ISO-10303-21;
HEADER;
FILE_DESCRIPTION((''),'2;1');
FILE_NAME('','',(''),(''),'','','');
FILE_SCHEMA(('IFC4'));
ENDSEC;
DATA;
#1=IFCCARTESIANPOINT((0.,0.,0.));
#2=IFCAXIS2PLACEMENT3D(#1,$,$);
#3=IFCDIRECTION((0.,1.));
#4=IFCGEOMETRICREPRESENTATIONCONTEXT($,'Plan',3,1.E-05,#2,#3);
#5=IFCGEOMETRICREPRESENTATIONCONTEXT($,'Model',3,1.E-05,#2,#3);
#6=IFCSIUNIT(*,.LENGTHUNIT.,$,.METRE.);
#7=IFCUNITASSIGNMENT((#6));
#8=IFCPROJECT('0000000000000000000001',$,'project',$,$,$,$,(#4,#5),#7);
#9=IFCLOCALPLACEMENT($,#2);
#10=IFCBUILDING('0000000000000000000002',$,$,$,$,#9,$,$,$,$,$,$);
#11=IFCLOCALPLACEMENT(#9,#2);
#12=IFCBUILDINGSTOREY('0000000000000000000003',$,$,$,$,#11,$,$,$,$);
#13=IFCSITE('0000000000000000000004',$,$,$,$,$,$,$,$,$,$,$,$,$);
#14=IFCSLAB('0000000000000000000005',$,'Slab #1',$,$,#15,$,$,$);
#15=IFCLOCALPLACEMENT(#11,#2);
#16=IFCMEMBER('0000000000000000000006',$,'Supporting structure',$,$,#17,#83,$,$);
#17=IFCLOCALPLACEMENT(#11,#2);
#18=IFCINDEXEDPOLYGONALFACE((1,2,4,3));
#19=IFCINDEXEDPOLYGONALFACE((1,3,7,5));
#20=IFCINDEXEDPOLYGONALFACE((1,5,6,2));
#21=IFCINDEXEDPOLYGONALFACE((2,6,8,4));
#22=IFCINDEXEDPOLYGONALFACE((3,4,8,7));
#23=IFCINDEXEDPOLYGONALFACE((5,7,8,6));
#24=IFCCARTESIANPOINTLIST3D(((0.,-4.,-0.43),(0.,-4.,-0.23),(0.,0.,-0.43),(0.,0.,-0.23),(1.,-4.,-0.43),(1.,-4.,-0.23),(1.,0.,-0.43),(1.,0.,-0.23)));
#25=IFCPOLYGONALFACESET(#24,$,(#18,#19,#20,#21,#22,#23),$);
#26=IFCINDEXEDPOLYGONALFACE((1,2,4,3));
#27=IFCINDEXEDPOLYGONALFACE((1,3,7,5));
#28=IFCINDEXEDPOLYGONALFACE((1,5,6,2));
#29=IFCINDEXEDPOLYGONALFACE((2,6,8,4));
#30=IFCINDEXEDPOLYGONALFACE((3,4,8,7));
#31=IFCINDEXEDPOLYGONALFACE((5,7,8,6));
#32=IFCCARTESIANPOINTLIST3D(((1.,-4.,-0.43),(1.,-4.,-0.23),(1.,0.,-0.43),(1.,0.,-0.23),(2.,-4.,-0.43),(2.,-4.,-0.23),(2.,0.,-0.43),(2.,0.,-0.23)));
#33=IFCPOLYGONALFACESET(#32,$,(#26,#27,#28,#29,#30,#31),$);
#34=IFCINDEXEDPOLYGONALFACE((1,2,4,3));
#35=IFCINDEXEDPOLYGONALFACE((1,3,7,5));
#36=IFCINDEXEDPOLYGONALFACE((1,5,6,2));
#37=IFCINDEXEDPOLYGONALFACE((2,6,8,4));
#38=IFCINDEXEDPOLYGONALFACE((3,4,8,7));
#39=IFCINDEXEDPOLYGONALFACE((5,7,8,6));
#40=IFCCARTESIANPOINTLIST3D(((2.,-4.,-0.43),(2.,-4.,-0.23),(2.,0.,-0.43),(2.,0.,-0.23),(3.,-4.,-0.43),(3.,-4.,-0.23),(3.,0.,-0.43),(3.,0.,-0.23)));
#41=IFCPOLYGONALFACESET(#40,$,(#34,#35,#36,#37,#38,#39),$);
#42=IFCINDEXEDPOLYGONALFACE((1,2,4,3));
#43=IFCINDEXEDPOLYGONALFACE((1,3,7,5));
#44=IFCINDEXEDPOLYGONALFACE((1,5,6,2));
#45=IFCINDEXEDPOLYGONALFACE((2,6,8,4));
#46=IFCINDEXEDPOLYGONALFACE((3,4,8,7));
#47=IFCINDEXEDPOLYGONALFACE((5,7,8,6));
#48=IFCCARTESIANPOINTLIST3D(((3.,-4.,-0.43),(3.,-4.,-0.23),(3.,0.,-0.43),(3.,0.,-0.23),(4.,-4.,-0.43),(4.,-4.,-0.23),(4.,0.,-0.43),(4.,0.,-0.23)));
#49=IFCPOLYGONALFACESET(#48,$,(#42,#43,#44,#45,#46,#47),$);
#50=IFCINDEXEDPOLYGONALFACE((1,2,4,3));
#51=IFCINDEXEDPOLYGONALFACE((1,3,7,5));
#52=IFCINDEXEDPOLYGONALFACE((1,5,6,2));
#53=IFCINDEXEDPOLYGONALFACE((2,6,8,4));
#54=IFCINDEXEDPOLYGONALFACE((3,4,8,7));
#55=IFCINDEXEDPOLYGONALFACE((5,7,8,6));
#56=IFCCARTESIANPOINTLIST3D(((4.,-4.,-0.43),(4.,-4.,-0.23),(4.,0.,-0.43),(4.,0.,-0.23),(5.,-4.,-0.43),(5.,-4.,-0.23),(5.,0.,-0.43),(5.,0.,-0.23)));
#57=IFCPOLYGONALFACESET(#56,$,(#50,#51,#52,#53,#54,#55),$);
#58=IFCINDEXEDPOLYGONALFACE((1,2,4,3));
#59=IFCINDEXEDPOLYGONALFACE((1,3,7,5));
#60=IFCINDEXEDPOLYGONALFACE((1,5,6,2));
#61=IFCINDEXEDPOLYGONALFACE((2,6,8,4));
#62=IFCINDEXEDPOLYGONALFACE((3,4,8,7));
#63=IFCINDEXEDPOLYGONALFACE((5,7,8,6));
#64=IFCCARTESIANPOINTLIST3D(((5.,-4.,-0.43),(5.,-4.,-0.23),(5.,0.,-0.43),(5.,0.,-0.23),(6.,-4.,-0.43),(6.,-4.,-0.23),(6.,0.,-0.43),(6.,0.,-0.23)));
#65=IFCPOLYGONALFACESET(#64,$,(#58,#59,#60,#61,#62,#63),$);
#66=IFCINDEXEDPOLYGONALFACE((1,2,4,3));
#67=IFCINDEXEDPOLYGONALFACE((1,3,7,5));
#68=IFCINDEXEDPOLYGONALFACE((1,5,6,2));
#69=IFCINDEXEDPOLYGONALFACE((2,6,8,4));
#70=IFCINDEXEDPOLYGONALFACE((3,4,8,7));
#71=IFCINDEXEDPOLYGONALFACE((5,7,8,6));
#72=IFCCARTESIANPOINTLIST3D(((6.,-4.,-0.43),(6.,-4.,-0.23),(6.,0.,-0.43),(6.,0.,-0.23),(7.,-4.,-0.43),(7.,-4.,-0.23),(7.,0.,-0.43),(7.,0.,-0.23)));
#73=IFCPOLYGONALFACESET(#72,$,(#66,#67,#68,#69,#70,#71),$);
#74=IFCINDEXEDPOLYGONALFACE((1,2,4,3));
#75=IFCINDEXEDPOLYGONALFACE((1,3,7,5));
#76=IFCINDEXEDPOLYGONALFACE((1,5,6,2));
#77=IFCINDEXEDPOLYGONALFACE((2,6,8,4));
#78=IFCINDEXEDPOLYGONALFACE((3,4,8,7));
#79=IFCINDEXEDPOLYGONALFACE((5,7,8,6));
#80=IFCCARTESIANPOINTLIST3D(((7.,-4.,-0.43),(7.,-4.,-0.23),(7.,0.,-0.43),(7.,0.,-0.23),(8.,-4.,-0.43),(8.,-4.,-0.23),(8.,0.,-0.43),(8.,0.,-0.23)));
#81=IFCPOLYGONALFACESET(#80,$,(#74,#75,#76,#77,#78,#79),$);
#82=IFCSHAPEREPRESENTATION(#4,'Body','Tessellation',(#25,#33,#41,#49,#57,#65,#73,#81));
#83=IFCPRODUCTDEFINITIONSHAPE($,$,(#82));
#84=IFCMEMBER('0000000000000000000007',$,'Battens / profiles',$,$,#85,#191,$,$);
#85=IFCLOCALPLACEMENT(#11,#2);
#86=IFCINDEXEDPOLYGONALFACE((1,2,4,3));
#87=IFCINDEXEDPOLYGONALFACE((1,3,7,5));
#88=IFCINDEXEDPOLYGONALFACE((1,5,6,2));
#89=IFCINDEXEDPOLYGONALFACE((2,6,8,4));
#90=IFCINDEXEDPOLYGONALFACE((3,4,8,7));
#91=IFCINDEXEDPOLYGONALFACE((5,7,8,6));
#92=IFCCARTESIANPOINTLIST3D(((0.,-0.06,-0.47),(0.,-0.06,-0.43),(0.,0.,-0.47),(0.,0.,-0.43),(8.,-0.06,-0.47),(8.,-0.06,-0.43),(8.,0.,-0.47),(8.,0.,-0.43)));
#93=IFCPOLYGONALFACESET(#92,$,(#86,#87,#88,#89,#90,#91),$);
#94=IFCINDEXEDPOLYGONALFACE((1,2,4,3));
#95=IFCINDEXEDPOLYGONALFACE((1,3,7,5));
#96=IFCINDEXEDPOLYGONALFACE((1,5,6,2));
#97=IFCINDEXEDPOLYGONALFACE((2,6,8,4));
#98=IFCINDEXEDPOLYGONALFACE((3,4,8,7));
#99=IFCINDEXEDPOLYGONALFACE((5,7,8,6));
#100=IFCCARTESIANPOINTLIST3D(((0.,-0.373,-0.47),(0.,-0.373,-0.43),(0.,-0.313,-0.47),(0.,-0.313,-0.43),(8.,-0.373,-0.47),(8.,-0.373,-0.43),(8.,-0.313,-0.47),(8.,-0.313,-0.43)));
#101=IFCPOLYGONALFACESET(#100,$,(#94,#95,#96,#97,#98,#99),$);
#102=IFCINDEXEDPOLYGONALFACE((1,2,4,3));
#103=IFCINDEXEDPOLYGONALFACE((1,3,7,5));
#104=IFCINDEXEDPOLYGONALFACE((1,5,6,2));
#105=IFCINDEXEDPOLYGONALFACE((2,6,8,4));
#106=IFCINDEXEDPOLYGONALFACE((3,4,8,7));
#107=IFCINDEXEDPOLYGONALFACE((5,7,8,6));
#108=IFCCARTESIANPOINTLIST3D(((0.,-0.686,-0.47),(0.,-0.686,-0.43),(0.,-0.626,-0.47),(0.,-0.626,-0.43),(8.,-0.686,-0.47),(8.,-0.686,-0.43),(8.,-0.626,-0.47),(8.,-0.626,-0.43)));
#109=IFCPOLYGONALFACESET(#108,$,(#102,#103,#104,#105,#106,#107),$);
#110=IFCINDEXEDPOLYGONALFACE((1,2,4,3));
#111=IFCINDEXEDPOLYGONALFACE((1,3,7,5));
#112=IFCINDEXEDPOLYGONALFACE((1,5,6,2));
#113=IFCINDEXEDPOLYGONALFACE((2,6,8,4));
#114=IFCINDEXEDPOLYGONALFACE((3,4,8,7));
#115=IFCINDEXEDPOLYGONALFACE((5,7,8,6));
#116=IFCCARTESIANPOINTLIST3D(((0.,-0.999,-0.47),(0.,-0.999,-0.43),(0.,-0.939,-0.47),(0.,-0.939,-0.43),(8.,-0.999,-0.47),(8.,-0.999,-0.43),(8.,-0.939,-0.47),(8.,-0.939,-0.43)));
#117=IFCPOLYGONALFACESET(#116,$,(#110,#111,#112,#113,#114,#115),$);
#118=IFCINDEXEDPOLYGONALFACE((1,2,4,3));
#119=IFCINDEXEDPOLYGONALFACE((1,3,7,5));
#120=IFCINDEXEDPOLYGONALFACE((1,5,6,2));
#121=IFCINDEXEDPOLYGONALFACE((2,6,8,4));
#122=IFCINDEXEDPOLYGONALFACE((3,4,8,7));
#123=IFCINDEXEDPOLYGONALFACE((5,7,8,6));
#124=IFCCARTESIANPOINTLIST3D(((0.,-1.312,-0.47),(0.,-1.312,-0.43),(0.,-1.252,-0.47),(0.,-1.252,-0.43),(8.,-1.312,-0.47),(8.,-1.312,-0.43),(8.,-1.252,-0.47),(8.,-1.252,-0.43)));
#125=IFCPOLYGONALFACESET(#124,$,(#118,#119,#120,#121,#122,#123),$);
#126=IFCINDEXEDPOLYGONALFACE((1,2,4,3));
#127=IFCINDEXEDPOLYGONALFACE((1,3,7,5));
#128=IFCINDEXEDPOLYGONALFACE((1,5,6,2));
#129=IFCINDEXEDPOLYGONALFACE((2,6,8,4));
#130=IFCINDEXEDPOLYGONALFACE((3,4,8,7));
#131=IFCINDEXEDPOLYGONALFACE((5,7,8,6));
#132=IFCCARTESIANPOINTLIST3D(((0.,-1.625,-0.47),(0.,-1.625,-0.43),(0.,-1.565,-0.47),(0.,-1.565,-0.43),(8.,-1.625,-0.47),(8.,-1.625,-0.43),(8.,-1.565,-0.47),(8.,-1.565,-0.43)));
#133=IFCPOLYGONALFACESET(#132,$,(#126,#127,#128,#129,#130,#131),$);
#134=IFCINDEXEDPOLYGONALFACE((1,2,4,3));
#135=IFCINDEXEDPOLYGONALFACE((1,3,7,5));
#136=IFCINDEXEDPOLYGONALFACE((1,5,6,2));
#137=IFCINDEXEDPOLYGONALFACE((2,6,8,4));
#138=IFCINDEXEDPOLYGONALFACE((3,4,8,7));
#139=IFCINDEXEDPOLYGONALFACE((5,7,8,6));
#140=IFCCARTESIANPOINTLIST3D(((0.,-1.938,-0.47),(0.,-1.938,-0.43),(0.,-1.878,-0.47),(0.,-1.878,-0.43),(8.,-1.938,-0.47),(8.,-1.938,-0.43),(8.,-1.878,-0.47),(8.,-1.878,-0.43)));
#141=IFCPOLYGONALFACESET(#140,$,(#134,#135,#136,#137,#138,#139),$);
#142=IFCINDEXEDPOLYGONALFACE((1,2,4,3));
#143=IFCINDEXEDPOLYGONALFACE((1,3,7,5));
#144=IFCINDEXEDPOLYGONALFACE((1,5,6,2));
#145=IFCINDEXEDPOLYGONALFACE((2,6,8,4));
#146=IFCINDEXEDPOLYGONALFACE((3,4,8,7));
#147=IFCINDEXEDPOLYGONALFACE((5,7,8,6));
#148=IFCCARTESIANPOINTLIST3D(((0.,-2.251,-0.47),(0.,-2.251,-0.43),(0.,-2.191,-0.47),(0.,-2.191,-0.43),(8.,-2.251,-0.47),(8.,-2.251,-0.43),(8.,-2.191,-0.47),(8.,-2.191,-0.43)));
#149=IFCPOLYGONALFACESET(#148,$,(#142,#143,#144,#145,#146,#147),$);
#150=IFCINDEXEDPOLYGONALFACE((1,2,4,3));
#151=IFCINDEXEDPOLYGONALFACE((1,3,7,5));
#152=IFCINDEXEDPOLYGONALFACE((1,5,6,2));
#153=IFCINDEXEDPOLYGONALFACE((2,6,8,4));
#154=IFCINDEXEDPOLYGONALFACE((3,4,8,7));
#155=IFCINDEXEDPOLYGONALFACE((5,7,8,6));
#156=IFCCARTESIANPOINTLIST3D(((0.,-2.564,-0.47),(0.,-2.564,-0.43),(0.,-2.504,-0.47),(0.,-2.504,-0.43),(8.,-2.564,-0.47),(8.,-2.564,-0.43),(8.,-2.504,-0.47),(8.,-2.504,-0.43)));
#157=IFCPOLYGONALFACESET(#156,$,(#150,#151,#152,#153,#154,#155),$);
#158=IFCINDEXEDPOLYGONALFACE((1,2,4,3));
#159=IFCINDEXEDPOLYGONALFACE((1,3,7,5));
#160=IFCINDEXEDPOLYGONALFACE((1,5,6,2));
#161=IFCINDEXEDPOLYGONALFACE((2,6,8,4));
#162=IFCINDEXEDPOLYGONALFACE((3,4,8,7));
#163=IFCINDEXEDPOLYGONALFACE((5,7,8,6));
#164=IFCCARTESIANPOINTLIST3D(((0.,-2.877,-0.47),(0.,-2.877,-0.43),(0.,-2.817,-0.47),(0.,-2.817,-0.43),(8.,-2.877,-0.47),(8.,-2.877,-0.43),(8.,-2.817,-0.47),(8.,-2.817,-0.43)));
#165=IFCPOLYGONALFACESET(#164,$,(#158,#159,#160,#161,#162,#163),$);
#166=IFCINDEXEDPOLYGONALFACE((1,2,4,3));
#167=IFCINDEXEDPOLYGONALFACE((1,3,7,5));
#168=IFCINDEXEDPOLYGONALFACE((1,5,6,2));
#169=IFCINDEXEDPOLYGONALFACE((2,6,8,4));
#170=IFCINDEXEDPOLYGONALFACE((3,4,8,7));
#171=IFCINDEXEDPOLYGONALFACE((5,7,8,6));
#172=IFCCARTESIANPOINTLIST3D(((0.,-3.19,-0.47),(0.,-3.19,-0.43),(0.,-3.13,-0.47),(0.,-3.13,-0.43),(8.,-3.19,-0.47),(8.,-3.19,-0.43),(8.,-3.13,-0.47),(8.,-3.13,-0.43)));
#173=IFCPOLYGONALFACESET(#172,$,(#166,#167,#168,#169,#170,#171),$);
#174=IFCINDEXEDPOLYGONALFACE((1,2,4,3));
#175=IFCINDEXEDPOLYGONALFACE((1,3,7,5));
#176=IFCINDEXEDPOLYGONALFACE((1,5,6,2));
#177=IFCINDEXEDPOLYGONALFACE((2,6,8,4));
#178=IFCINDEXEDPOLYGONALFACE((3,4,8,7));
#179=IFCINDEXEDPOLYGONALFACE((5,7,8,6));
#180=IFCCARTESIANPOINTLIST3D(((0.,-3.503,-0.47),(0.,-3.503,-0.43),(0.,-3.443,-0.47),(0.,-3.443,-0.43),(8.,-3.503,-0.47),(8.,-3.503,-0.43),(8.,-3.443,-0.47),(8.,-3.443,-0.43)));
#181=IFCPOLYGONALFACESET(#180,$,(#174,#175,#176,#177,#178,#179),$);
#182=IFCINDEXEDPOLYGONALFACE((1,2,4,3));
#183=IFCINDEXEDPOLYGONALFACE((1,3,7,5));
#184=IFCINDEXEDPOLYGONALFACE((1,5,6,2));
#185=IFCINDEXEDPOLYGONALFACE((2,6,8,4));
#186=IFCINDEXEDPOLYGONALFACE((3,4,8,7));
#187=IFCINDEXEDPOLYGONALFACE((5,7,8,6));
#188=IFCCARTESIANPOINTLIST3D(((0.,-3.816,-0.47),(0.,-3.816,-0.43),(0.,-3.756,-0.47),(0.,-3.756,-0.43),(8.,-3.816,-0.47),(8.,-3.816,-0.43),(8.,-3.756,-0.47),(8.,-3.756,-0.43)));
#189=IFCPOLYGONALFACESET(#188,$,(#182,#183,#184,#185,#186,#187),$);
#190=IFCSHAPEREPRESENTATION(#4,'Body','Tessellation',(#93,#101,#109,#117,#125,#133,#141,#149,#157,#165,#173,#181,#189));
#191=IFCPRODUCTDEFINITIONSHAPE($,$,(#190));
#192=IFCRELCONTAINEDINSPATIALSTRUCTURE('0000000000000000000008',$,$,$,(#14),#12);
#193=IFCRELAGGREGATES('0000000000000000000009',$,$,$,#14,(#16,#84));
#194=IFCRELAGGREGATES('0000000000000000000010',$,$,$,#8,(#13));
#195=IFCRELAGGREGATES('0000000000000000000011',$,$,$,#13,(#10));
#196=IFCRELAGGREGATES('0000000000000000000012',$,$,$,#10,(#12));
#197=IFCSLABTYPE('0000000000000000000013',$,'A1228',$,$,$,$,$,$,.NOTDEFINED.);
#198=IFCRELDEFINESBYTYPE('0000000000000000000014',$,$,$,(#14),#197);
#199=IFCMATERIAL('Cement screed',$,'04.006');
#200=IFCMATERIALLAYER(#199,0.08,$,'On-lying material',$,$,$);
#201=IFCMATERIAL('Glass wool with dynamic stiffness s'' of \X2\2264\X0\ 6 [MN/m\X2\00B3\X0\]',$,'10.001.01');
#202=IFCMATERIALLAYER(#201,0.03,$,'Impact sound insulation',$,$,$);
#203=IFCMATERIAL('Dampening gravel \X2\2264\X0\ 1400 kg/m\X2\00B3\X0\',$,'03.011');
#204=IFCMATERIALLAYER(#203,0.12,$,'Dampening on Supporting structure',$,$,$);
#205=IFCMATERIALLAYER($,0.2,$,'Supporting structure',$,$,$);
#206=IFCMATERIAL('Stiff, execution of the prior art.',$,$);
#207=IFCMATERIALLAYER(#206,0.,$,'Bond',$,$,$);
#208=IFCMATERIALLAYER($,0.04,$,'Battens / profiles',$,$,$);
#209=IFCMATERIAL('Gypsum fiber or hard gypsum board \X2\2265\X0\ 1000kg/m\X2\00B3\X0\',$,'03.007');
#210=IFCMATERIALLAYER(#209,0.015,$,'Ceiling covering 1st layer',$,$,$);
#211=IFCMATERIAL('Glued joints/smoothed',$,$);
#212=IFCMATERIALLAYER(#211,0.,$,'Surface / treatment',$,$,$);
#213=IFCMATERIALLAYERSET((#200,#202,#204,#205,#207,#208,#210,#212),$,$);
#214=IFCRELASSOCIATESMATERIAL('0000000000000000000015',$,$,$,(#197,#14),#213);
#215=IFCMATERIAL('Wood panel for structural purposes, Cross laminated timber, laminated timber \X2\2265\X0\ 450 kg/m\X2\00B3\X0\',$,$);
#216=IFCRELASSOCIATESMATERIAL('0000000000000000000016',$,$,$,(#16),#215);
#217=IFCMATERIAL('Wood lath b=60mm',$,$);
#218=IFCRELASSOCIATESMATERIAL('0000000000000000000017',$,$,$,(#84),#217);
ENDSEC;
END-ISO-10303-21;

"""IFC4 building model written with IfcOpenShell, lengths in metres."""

from ifc_helpers import new_model, si_unit, direction, frame, frame_2d, origin, place, context, project, spatial, rectangle, extrude, material, layer, layer_set, type_object, element, aggregate, save


model = new_model("IFC4")

# Units and contexts
plan_context = context("Plan", 3, precision=1e-05, world=origin(), true_north=direction((0.0, 1.0)))
model_context = context("Model", 3, precision=1e-05, world=origin(), true_north=direction((0.0, 1.0)))
ifc_project = project(units=[si_unit("LENGTHUNIT", "METRE")], contexts=[plan_context, model_context])

# Site, building, storey
site = spatial("IfcSite", under=ifc_project)
building_placement = place(None, origin())
building = spatial("IfcBuilding", under=site, at=building_placement)
storey_placement = place(building_placement, origin())
storey = spatial("IfcBuildingStorey", under=building, at=storey_placement)

# Slab, members
ifc_material_1 = material(Name="Cement screed", Category="04.006")
ifc_layer_1 = layer(ifc_material_1, 0.08, Name="On-lying material")
ifc_material_2 = material(Name="Glass wool with dynamic stiffness s' of ≤ 6 [MN/m³]", Category="10.001.01")
ifc_layer_2 = layer(ifc_material_2, 0.03, Name="Impact sound insulation")
ifc_material_3 = material(Name="Dampening gravel ≤ 1400 kg/m³", Category="03.011")
ifc_layer_3 = layer(ifc_material_3, 0.12, Name="Dampening on Supporting structure")
ifc_layer_4 = layer(None, 0.2, Name="Supporting structure")
ifc_material_4 = material(Name="Stiff, execution of the prior art.")
ifc_layer_5 = layer(ifc_material_4, 0.0, Name="Bond")
ifc_layer_6 = layer(None, 0.04, Name="Battens / profiles")
ifc_material_5 = material(Name="Gypsum fiber or hard gypsum board ≥ 1000kg/m³", Category="03.007")
ifc_layer_7 = layer(ifc_material_5, 0.015, Name="Ceiling covering 1st layer")
ifc_material_6 = material(Name="Glued joints/smoothed")
ifc_layer_8 = layer(ifc_material_6, 0.0, Name="Surface / treatment")
ifc_layer_set = layer_set([ifc_layer_1, ifc_layer_2, ifc_layer_3, ifc_layer_4, ifc_layer_5, ifc_layer_6, ifc_layer_7, ifc_layer_8])
slab_type = type_object("IfcSlabType", Name="A1228", PredefinedType="NOTDEFINED", material=ifc_layer_set)
slab_placement = place(None, frame((0.0, 0.0, 0.0), z_axis=(0.0, 0.0, -1.0), x_axis=(1.0, 0.0, 0.0)))
slab = element("IfcSlab", 1, at=slab_placement, inside=storey, type_object=slab_type, material=ifc_layer_set, Name="Slab #1")
ifc_material_7 = material(Name="Wood panel for structural purposes, Cross laminated timber, laminated timber ≥ 450 kg/m³")
member_1_placement = place(slab_placement, origin())
member_1 = element("IfcMember", 2, at=member_1_placement, material=ifc_material_7, Name="Supporting structure", context=plan_context, shape_type="SweptSolid", body=[
    extrude(rectangle(XDim=1.0, YDim=0.2, at=frame_2d((0.5, 0.1), x_axis=(1.0, 0.0))), frame((0.0, 4.0, 0.23), z_axis=(0.0, -1.0, 0.0), x_axis=(1.0, 0.0, 0.0)), (0.0, 0.0, 1.0), 4.0),
    extrude(rectangle(XDim=1.0, YDim=0.2, at=frame_2d((0.5, 0.1), x_axis=(1.0, 0.0))), frame((1.0, 4.0, 0.23), z_axis=(0.0, -1.0, 0.0), x_axis=(1.0, 0.0, 0.0)), (0.0, 0.0, 1.0), 4.0),
    extrude(rectangle(XDim=1.0, YDim=0.2, at=frame_2d((0.5, 0.1), x_axis=(1.0, 0.0))), frame((2.0, 4.0, 0.23), z_axis=(0.0, -1.0, 0.0), x_axis=(1.0, 0.0, 0.0)), (0.0, 0.0, 1.0), 4.0),
    extrude(rectangle(XDim=1.0, YDim=0.2, at=frame_2d((0.5, 0.1), x_axis=(1.0, 0.0))), frame((3.0, 4.0, 0.23), z_axis=(0.0, -1.0, 0.0), x_axis=(1.0, 0.0, 0.0)), (0.0, 0.0, 1.0), 4.0),
    extrude(rectangle(XDim=1.0, YDim=0.2, at=frame_2d((0.5, 0.1), x_axis=(1.0, 0.0))), frame((4.0, 4.0, 0.23), z_axis=(0.0, -1.0, 0.0), x_axis=(1.0, 0.0, 0.0)), (0.0, 0.0, 1.0), 4.0),
    extrude(rectangle(XDim=1.0, YDim=0.2, at=frame_2d((0.5, 0.1), x_axis=(1.0, 0.0))), frame((5.0, 4.0, 0.23), z_axis=(0.0, -1.0, 0.0), x_axis=(1.0, 0.0, 0.0)), (0.0, 0.0, 1.0), 4.0),
    extrude(rectangle(XDim=1.0, YDim=0.2, at=frame_2d((0.5, 0.1), x_axis=(1.0, 0.0))), frame((6.0, 4.0, 0.23), z_axis=(0.0, -1.0, 0.0), x_axis=(1.0, 0.0, 0.0)), (0.0, 0.0, 1.0), 4.0),
    extrude(rectangle(XDim=1.0, YDim=0.2, at=frame_2d((0.5, 0.1), x_axis=(1.0, 0.0))), frame((7.0, 4.0, 0.23), z_axis=(0.0, -1.0, 0.0), x_axis=(1.0, 0.0, 0.0)), (0.0, 0.0, 1.0), 4.0),
])
ifc_material_8 = material(Name="Wood lath b=60mm")
member_2_placement = place(slab_placement, origin())
member_2 = element("IfcMember", 3, at=member_2_placement, material=ifc_material_8, Name="Battens / profiles", context=plan_context, shape_type="SweptSolid", body=[
    extrude(rectangle(XDim=0.06, YDim=0.04, at=frame_2d((0.03, 0.02), x_axis=(1.0, 0.0))), frame((0.0, 0.0, 0.43), z_axis=(1.0, 0.0, 0.0), x_axis=(0.0, 1.0, 0.0)), (0.0, 0.0, 1.0), 8.0),
    extrude(rectangle(XDim=0.06, YDim=0.04, at=frame_2d((0.03, 0.02), x_axis=(1.0, 0.0))), frame((0.0, 0.313, 0.43), z_axis=(1.0, 0.0, 0.0), x_axis=(0.0, 1.0, 0.0)), (0.0, 0.0, 1.0), 8.0),
    extrude(rectangle(XDim=0.06, YDim=0.04, at=frame_2d((0.03, 0.02), x_axis=(1.0, 0.0))), frame((0.0, 0.626, 0.43), z_axis=(1.0, 0.0, 0.0), x_axis=(0.0, 1.0, 0.0)), (0.0, 0.0, 1.0), 8.0),
    extrude(rectangle(XDim=0.06, YDim=0.04, at=frame_2d((0.03, 0.02), x_axis=(1.0, 0.0))), frame((0.0, 0.939, 0.43), z_axis=(1.0, 0.0, 0.0), x_axis=(0.0, 1.0, 0.0)), (0.0, 0.0, 1.0), 8.0),
    extrude(rectangle(XDim=0.06, YDim=0.04, at=frame_2d((0.03, 0.02), x_axis=(1.0, 0.0))), frame((0.0, 1.252, 0.43), z_axis=(1.0, 0.0, 0.0), x_axis=(0.0, 1.0, 0.0)), (0.0, 0.0, 1.0), 8.0),
    extrude(rectangle(XDim=0.06, YDim=0.04, at=frame_2d((0.03, 0.02), x_axis=(1.0, 0.0))), frame((0.0, 1.565, 0.43), z_axis=(1.0, 0.0, 0.0), x_axis=(0.0, 1.0, 0.0)), (0.0, 0.0, 1.0), 8.0),
    extrude(rectangle(XDim=0.06, YDim=0.04, at=frame_2d((0.03, 0.02), x_axis=(1.0, 0.0))), frame((0.0, 1.878, 0.43), z_axis=(1.0, 0.0, 0.0), x_axis=(0.0, 1.0, 0.0)), (0.0, 0.0, 1.0), 8.0),
    extrude(rectangle(XDim=0.06, YDim=0.04, at=frame_2d((0.03, 0.02), x_axis=(1.0, 0.0))), frame((0.0, 2.191, 0.43), z_axis=(1.0, 0.0, 0.0), x_axis=(0.0, 1.0, 0.0)), (0.0, 0.0, 1.0), 8.0),
    extrude(rectangle(XDim=0.06, YDim=0.04, at=frame_2d((0.03, 0.02), x_axis=(1.0, 0.0))), frame((0.0, 2.504, 0.43), z_axis=(1.0, 0.0, 0.0), x_axis=(0.0, 1.0, 0.0)), (0.0, 0.0, 1.0), 8.0),
    extrude(rectangle(XDim=0.06, YDim=0.04, at=frame_2d((0.03, 0.02), x_axis=(1.0, 0.0))), frame((0.0, 2.817, 0.43), z_axis=(1.0, 0.0, 0.0), x_axis=(0.0, 1.0, 0.0)), (0.0, 0.0, 1.0), 8.0),
    extrude(rectangle(XDim=0.06, YDim=0.04, at=frame_2d((0.03, 0.02), x_axis=(1.0, 0.0))), frame((0.0, 3.13, 0.43), z_axis=(1.0, 0.0, 0.0), x_axis=(0.0, 1.0, 0.0)), (0.0, 0.0, 1.0), 8.0),
    extrude(rectangle(XDim=0.06, YDim=0.04, at=frame_2d((0.03, 0.02), x_axis=(1.0, 0.0))), frame((0.0, 3.443, 0.43), z_axis=(1.0, 0.0, 0.0), x_axis=(0.0, 1.0, 0.0)), (0.0, 0.0, 1.0), 8.0),
    extrude(rectangle(XDim=0.06, YDim=0.04, at=frame_2d((0.03, 0.02), x_axis=(1.0, 0.0))), frame((0.0, 3.756, 0.43), z_axis=(1.0, 0.0, 0.0), x_axis=(0.0, 1.0, 0.0)), (0.0, 0.0, 1.0), 8.0),
])
aggregate(slab, [member_1, member_2])

save(model, "model.ifc")
